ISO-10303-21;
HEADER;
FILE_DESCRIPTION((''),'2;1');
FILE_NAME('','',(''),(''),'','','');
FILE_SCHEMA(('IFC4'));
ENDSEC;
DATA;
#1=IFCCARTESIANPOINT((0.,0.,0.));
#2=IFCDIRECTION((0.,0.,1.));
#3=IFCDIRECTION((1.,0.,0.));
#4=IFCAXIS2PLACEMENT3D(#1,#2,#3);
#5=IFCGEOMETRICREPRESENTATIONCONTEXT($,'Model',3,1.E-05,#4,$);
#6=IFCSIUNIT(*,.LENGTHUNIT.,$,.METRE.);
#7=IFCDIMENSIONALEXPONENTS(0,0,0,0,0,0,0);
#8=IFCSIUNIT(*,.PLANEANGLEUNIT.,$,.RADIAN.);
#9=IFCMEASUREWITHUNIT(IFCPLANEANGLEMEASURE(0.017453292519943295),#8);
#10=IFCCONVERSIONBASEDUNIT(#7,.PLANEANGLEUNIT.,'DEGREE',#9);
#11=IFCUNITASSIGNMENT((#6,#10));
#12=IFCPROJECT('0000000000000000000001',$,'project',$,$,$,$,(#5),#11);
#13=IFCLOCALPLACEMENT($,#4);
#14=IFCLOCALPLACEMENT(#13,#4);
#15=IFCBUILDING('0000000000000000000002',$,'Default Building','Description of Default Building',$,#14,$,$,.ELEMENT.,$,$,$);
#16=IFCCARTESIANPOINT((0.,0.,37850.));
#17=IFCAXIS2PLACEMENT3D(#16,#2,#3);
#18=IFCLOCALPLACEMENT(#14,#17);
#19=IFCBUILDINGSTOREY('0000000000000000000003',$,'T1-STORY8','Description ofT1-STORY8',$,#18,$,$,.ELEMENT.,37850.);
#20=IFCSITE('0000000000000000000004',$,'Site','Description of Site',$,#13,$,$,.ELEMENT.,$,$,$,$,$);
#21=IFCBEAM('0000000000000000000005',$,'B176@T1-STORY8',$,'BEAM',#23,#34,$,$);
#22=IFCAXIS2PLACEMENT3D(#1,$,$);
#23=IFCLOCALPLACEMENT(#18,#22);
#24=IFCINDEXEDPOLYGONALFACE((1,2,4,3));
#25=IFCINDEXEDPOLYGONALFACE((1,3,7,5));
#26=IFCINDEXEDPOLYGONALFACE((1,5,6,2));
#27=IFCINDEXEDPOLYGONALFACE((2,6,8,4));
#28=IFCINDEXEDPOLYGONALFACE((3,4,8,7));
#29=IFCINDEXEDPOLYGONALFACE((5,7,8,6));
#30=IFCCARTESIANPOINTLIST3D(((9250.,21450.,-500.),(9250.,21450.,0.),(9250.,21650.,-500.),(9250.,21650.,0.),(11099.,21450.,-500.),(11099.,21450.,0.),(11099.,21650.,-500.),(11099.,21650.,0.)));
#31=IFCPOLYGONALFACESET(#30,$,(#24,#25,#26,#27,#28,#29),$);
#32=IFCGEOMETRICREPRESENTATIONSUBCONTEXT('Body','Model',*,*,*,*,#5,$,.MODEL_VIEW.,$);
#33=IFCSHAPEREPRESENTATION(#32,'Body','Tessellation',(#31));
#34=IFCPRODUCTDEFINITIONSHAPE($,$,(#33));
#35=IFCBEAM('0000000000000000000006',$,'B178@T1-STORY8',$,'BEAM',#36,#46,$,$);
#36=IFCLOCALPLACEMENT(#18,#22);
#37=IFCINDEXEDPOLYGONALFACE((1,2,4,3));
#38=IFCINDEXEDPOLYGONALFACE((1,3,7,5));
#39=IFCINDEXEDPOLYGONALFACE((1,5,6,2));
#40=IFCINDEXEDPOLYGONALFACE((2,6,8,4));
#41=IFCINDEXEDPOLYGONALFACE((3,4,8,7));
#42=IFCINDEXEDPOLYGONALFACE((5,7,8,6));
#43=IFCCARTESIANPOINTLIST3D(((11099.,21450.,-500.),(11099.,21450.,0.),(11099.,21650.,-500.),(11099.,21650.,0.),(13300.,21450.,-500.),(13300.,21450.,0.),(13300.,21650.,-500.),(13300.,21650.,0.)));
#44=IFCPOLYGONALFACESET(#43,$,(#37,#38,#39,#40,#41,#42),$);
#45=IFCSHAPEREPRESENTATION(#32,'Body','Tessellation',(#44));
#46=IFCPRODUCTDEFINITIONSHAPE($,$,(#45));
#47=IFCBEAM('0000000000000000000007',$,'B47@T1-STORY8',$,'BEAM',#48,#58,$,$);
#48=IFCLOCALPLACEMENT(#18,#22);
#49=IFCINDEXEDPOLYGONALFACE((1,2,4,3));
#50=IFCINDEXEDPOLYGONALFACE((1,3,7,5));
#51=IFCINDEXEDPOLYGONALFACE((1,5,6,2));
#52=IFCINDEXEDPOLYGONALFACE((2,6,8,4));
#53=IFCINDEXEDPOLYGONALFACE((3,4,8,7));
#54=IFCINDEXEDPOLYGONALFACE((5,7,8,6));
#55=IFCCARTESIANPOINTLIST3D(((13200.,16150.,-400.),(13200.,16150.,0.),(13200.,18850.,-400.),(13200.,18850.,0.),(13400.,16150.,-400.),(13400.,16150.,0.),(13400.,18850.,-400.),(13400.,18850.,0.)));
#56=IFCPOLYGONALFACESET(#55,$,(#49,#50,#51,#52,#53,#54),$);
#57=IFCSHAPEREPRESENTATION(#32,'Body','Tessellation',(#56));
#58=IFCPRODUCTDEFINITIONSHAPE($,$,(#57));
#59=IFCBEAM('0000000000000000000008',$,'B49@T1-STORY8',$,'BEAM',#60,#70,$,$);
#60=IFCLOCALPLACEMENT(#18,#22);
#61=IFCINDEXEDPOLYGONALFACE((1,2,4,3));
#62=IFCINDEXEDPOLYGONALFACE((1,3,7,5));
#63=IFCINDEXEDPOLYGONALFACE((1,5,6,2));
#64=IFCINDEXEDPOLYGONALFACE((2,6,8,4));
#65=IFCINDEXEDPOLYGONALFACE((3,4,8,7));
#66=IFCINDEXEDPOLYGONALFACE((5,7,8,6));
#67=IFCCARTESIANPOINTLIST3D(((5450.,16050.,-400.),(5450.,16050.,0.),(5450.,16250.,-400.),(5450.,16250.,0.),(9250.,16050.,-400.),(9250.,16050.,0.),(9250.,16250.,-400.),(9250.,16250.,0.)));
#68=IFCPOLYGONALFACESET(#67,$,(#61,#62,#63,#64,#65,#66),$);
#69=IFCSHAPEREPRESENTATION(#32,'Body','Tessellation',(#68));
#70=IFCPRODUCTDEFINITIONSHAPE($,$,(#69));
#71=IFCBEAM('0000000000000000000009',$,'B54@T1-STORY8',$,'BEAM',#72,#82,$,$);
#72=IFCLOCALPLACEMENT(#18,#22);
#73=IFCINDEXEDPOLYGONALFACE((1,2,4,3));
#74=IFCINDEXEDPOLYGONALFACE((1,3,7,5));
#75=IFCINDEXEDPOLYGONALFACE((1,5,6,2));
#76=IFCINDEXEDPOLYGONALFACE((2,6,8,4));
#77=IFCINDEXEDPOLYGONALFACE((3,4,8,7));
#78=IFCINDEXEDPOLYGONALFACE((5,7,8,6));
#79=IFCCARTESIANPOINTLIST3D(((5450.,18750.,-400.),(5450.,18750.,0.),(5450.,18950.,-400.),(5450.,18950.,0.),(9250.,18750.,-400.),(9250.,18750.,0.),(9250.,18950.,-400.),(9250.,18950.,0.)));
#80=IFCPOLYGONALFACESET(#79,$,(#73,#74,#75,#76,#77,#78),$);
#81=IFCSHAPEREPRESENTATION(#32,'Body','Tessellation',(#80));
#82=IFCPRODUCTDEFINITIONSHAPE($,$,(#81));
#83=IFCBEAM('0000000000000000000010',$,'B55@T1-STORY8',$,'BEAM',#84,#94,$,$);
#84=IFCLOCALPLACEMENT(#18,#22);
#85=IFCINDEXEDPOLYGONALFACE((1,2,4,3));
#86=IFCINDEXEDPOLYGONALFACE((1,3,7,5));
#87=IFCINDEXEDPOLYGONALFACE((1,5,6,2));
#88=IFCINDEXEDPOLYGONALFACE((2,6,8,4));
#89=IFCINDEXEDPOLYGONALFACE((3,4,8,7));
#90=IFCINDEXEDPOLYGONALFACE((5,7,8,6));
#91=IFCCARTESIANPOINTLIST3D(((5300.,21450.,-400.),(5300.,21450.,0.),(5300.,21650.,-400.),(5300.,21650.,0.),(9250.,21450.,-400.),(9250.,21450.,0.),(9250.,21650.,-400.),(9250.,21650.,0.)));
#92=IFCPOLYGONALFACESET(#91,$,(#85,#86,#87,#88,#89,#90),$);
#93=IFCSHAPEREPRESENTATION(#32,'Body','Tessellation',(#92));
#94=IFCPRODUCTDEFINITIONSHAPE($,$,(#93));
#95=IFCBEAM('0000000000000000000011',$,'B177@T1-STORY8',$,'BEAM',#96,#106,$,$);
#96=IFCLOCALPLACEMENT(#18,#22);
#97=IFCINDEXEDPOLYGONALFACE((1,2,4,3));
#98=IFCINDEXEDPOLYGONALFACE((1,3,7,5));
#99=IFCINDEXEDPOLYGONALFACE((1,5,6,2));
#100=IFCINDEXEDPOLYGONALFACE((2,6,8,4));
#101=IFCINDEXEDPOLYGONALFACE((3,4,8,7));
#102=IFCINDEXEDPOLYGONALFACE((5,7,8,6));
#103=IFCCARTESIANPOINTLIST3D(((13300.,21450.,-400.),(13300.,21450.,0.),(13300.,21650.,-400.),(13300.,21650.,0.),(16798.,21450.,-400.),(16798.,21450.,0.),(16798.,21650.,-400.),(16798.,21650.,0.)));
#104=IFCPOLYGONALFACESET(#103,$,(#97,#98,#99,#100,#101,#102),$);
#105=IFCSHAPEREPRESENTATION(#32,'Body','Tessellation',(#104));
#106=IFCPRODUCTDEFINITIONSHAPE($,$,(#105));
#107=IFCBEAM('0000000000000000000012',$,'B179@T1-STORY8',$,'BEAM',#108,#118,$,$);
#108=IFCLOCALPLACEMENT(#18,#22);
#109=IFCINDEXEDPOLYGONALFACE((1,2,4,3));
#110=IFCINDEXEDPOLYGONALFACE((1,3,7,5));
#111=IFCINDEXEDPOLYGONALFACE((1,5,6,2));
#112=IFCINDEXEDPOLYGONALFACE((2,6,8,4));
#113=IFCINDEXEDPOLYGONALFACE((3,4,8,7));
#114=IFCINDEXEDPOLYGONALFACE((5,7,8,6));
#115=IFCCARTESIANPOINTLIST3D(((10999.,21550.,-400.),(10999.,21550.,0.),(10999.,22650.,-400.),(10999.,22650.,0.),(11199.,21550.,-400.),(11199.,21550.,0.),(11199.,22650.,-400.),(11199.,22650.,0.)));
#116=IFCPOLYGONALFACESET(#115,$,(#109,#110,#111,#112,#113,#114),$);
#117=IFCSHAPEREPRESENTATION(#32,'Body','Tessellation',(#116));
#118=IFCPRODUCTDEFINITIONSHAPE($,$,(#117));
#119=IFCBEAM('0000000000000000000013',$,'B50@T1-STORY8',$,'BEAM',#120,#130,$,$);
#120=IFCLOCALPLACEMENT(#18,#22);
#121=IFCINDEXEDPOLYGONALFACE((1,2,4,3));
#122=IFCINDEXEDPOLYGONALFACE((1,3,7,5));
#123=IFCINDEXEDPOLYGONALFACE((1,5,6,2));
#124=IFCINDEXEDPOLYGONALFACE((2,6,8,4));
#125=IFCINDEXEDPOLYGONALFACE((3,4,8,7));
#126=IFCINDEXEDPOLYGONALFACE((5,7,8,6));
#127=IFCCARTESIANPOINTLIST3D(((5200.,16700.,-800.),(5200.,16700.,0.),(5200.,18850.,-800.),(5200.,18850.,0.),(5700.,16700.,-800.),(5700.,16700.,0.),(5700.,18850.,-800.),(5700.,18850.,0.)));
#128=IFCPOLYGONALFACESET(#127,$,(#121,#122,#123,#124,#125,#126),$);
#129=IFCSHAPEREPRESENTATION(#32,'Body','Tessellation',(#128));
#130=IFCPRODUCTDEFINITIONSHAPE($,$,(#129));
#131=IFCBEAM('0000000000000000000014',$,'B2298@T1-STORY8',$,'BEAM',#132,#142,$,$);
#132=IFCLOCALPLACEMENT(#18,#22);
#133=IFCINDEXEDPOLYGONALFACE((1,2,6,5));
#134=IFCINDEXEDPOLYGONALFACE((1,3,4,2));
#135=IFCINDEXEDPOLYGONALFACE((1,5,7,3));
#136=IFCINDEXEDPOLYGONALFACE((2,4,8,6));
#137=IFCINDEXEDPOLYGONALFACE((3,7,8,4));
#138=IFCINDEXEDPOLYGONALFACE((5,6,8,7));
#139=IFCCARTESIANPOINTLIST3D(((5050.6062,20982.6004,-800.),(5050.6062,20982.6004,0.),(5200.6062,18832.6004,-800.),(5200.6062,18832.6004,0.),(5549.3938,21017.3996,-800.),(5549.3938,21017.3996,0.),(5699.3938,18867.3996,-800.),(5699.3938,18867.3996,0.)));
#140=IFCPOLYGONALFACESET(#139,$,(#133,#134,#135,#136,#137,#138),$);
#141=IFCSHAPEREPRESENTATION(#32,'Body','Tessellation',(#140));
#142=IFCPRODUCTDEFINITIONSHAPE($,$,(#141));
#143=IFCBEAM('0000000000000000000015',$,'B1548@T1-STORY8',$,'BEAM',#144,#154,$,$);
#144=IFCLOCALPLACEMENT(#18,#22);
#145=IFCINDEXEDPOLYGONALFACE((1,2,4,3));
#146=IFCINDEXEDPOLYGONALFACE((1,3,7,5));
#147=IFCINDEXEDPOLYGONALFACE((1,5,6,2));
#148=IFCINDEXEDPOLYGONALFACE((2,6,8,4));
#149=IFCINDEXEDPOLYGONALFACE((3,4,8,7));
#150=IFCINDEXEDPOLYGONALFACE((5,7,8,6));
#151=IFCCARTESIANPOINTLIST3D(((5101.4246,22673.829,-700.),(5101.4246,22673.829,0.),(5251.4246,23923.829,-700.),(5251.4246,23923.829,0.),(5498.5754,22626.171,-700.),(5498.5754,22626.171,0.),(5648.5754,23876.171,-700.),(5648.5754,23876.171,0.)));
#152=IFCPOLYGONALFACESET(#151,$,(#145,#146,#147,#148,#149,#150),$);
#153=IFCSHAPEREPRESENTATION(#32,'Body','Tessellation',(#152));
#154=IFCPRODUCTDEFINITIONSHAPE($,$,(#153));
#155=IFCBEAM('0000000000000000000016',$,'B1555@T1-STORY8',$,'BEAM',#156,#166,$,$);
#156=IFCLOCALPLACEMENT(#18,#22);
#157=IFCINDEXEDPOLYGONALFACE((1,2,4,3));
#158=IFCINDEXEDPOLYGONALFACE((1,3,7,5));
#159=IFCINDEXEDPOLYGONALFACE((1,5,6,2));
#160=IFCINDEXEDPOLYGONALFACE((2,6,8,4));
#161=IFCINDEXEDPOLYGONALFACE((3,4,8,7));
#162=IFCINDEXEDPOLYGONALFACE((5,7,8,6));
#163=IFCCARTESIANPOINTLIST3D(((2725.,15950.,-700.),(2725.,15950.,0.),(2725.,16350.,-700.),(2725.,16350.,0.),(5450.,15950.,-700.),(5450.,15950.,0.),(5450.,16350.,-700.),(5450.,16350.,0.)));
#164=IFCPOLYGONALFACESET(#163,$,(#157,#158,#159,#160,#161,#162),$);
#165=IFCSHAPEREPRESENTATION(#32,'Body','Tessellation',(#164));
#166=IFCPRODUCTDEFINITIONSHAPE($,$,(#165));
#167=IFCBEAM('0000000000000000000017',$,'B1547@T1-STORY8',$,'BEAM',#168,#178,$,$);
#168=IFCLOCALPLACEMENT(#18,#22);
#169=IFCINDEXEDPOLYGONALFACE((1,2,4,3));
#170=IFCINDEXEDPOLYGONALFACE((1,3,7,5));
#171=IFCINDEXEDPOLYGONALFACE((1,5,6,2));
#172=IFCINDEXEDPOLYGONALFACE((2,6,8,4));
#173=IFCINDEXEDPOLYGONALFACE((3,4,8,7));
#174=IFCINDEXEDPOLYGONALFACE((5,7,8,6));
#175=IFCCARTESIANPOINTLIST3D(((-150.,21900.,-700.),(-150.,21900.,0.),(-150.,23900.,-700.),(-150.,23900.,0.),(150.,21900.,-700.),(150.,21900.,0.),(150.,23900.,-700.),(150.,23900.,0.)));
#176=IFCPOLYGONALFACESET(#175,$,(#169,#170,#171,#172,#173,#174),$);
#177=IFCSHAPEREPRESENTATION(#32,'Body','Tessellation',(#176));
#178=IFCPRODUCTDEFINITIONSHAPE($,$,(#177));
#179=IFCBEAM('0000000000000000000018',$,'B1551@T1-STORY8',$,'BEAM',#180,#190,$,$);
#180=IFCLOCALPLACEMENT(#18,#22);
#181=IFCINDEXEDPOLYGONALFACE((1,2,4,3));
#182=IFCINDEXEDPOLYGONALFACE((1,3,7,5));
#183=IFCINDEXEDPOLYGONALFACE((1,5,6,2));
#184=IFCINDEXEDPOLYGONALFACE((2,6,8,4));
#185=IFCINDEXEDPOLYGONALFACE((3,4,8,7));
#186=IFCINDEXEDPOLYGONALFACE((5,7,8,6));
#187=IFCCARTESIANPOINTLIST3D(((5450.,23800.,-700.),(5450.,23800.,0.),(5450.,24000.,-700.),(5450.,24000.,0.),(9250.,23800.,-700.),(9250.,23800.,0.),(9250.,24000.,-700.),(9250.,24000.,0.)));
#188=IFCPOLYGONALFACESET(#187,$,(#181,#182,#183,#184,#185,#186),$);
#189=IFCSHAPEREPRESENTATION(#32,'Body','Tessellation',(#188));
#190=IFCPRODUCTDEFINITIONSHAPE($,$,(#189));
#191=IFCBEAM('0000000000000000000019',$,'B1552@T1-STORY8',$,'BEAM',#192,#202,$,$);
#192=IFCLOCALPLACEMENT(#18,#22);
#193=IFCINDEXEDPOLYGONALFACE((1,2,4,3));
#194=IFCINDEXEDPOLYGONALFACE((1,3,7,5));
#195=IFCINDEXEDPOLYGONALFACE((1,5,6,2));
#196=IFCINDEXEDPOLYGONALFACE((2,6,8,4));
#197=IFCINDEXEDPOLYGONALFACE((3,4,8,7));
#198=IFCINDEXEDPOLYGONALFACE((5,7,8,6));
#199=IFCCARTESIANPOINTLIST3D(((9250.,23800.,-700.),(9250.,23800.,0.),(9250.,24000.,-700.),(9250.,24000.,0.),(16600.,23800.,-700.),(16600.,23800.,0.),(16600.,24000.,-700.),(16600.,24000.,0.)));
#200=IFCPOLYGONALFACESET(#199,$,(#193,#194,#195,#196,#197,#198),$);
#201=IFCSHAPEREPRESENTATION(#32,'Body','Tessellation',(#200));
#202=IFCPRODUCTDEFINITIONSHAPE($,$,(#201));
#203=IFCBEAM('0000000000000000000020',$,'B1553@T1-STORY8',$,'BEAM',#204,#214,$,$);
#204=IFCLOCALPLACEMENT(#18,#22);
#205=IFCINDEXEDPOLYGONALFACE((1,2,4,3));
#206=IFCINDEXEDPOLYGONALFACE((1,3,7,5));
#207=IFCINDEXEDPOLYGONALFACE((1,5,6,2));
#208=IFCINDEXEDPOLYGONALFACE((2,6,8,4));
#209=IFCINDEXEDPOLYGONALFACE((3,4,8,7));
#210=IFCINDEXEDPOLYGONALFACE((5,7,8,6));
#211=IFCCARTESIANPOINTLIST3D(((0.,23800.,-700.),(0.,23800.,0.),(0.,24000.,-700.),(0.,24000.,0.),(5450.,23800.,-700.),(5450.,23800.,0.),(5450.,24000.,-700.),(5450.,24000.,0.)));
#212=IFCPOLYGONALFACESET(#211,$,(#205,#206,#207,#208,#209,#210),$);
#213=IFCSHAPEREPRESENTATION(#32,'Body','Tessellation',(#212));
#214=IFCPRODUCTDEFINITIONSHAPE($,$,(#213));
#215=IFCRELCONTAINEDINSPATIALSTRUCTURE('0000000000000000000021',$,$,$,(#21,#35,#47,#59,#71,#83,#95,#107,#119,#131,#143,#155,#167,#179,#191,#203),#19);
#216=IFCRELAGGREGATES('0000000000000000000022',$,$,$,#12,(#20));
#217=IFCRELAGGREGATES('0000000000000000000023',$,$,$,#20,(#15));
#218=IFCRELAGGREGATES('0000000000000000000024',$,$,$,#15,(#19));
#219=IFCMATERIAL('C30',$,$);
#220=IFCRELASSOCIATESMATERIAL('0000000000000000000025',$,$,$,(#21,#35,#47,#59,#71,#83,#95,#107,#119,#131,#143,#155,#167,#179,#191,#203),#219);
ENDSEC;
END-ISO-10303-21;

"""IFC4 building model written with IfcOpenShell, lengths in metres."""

from ifc_helpers import new_model, entity, si_unit, converted_unit, frame, origin_with_axes, place, context, subcontext, project, spatial, rectangle, extrude, material, element, save


model = new_model("IFC4")

# Units and contexts
model_context = context("Model", 3, precision=1e-05, world=origin_with_axes())
body_context = subcontext(model_context, "Body", "Model", "MODEL_VIEW")
ifc_project = project(units=[si_unit("LENGTHUNIT", "METRE"), converted_unit("PLANEANGLEUNIT", "DEGREE", entity("IfcPlaneAngleMeasure", 0.017453292519943295), si_unit("PLANEANGLEUNIT", "RADIAN"), dimensions=[0, 0, 0, 0, 0, 0, 0])], contexts=[model_context])

# Site, building, storey
site_placement = place(None, origin_with_axes())
site = spatial("IfcSite", under=ifc_project, at=site_placement, Name="Site", Description="Description of Site", CompositionType="ELEMENT")
building_placement = place(site_placement, origin_with_axes())
building = spatial("IfcBuilding", under=site, at=building_placement, Name="Default Building", Description="Description of Default Building", CompositionType="ELEMENT")
storey_placement = place(building_placement, frame((0.0, 0.0, 37850.0), z_axis=(0.0, 0.0, 1.0), x_axis=(1.0, 0.0, 0.0)))
storey = spatial("IfcBuildingStorey", under=building, at=storey_placement, Name="T1-STORY8", Description="Description ofT1-STORY8", CompositionType="ELEMENT", Elevation=37850.0)

# Beams
ifc_material_1 = material(Name="C30")
beam_1_placement = place(storey_placement, frame((9250.0, 21550.0, -250.0), z_axis=(1.0, 0.0, 0.0), x_axis=(0.0, 1.0, 0.0)))
element("IfcBeam", 1, at=beam_1_placement, inside=storey, material=ifc_material_1, Name="B176@T1-STORY8", ObjectType="BEAM", context=body_context, shape_type="SweptSolid", body=[
    extrude(rectangle(XDim=200.0, YDim=500.0), origin_with_axes(), (0.0, 0.0, 1.0), 1849.0),
])
beam_2_placement = place(storey_placement, frame((11099.0, 21550.0, -250.0), z_axis=(1.0, 0.0, 0.0), x_axis=(0.0, 1.0, 0.0)))
element("IfcBeam", 2, at=beam_2_placement, inside=storey, material=ifc_material_1, Name="B178@T1-STORY8", ObjectType="BEAM", context=body_context, shape_type="SweptSolid", body=[
    extrude(rectangle(XDim=200.0, YDim=500.0), origin_with_axes(), (0.0, 0.0, 1.0), 2201.0),
])
beam_3_placement = place(storey_placement, frame((13300.0, 16150.0, -200.0), z_axis=(0.0, 1.0, 0.0), x_axis=(-1.0, 0.0, 0.0)))
element("IfcBeam", 3, at=beam_3_placement, inside=storey, material=ifc_material_1, Name="B47@T1-STORY8", ObjectType="BEAM", context=body_context, shape_type="SweptSolid", body=[
    extrude(rectangle(XDim=200.0, YDim=400.0), origin_with_axes(), (0.0, 0.0, 1.0), 2700.0),
])
for number, where, z_axis, x_axis, name in (
    (4, (5450.0, 16150.0, -200.0), (1.0, 0.0, 0.0), (0.0, 1.0, 0.0), "B49@T1-STORY8"),
    (5, (5450.0, 18850.0, -200.0), (1.0, 0.0, 0.0), (0.0, 1.0, 0.0), "B54@T1-STORY8"),
):
    element("IfcBeam", number, at=place(storey_placement, frame(where, z_axis=z_axis, x_axis=x_axis)), inside=storey, material=ifc_material_1, Name=name, ObjectType="BEAM", context=body_context, shape_type="SweptSolid", body=[
        extrude(rectangle(XDim=200.0, YDim=400.0), origin_with_axes(), (0.0, 0.0, 1.0), 3800.0),
    ])
beam_4_placement = place(storey_placement, frame((5300.0, 21550.0, -200.0), z_axis=(1.0, 0.0, 0.0), x_axis=(0.0, 1.0, 0.0)))
element("IfcBeam", 6, at=beam_4_placement, inside=storey, material=ifc_material_1, Name="B55@T1-STORY8", ObjectType="BEAM", context=body_context, shape_type="SweptSolid", body=[
    extrude(rectangle(XDim=200.0, YDim=400.0), origin_with_axes(), (0.0, 0.0, 1.0), 3950.0),
])
beam_5_placement = place(storey_placement, frame((13300.0, 21550.0, -200.0), z_axis=(1.0, 0.0, 0.0), x_axis=(0.0, 1.0, 0.0)))
element("IfcBeam", 7, at=beam_5_placement, inside=storey, material=ifc_material_1, Name="B177@T1-STORY8", ObjectType="BEAM", context=body_context, shape_type="SweptSolid", body=[
    extrude(rectangle(XDim=200.0, YDim=400.0), origin_with_axes(), (0.0, 0.0, 1.0), 3498.0),
])
beam_6_placement = place(storey_placement, frame((11099.0, 21550.0, -200.0), z_axis=(0.0, 1.0, 0.0), x_axis=(-1.0, 0.0, 0.0)))
element("IfcBeam", 8, at=beam_6_placement, inside=storey, material=ifc_material_1, Name="B179@T1-STORY8", ObjectType="BEAM", context=body_context, shape_type="SweptSolid", body=[
    extrude(rectangle(XDim=200.0, YDim=400.0), origin_with_axes(), (0.0, 0.0, 1.0), 1100.0),
])
beam_7_placement = place(storey_placement, frame((5450.0, 16700.0, -400.0), z_axis=(0.0, 1.0, 0.0), x_axis=(-1.0, 0.0, 0.0)))
element("IfcBeam", 9, at=beam_7_placement, inside=storey, material=ifc_material_1, Name="B50@T1-STORY8", ObjectType="BEAM", context=body_context, shape_type="SweptSolid", body=[
    extrude(rectangle(XDim=500.0, YDim=800.0), origin_with_axes(), (0.0, 0.0, 1.0), 2150.0),
])
beam_8_placement = place(storey_placement, frame((5300.0, 21000.0, -400.0), z_axis=(0.069598, -0.997575, 0.0), x_axis=(0.997575, 0.069598, 0.0)))
element("IfcBeam", 10, at=beam_8_placement, inside=storey, material=ifc_material_1, Name="B2298@T1-STORY8", ObjectType="BEAM", context=body_context, shape_type="SweptSolid", body=[
    extrude(rectangle(XDim=500.0, YDim=800.0), origin_with_axes(), (0.0, 0.0, 1.0), 2155.2262),
])
beam_9_placement = place(storey_placement, frame((5300.0, 22650.0, -350.0), z_axis=(0.119145, 0.992877, 0.0), x_axis=(-0.992877, 0.119145, 0.0)))
element("IfcBeam", 11, at=beam_9_placement, inside=storey, material=ifc_material_1, Name="B1548@T1-STORY8", ObjectType="BEAM", context=body_context, shape_type="SweptSolid", body=[
    extrude(rectangle(XDim=400.0, YDim=700.0), origin_with_axes(), (0.0, 0.0, 1.0), 1258.9678),
])
beam_10_placement = place(storey_placement, frame((2725.0, 16150.0, -350.0), z_axis=(1.0, 0.0, 0.0), x_axis=(0.0, 1.0, 0.0)))
element("IfcBeam", 12, at=beam_10_placement, inside=storey, material=ifc_material_1, Name="B1555@T1-STORY8", ObjectType="BEAM", context=body_context, shape_type="SweptSolid", body=[
    extrude(rectangle(XDim=400.0, YDim=700.0), origin_with_axes(), (0.0, 0.0, 1.0), 2725.0),
])
beam_11_placement = place(storey_placement, frame((0.0, 21900.0, -350.0), z_axis=(0.0, 1.0, 0.0), x_axis=(-1.0, 0.0, 0.0)))
element("IfcBeam", 13, at=beam_11_placement, inside=storey, material=ifc_material_1, Name="B1547@T1-STORY8", ObjectType="BEAM", context=body_context, shape_type="SweptSolid", body=[
    extrude(rectangle(XDim=300.0, YDim=700.0), origin_with_axes(), (0.0, 0.0, 1.0), 2000.0),
])
beam_12_placement = place(storey_placement, frame((5450.0, 23900.0, -350.0), z_axis=(1.0, 0.0, 0.0), x_axis=(0.0, 1.0, 0.0)))
element("IfcBeam", 14, at=beam_12_placement, inside=storey, material=ifc_material_1, Name="B1551@T1-STORY8", ObjectType="BEAM", context=body_context, shape_type="SweptSolid", body=[
    extrude(rectangle(XDim=200.0, YDim=700.0), origin_with_axes(), (0.0, 0.0, 1.0), 3800.0),
])
beam_13_placement = place(storey_placement, frame((9250.0, 23900.0, -350.0), z_axis=(1.0, 0.0, 0.0), x_axis=(0.0, 1.0, 0.0)))
element("IfcBeam", 15, at=beam_13_placement, inside=storey, material=ifc_material_1, Name="B1552@T1-STORY8", ObjectType="BEAM", context=body_context, shape_type="SweptSolid", body=[
    extrude(rectangle(XDim=200.0, YDim=700.0), origin_with_axes(), (0.0, 0.0, 1.0), 7350.0),
])
beam_14_placement = place(storey_placement, frame((0.0, 23900.0, -350.0), z_axis=(1.0, 0.0, 0.0), x_axis=(0.0, 1.0, 0.0)))
element("IfcBeam", 16, at=beam_14_placement, inside=storey, material=ifc_material_1, Name="B1553@T1-STORY8", ObjectType="BEAM", context=body_context, shape_type="SweptSolid", body=[
    extrude(rectangle(XDim=200.0, YDim=700.0), origin_with_axes(), (0.0, 0.0, 1.0), 5450.0),
])

save(model, "model.ifc")
